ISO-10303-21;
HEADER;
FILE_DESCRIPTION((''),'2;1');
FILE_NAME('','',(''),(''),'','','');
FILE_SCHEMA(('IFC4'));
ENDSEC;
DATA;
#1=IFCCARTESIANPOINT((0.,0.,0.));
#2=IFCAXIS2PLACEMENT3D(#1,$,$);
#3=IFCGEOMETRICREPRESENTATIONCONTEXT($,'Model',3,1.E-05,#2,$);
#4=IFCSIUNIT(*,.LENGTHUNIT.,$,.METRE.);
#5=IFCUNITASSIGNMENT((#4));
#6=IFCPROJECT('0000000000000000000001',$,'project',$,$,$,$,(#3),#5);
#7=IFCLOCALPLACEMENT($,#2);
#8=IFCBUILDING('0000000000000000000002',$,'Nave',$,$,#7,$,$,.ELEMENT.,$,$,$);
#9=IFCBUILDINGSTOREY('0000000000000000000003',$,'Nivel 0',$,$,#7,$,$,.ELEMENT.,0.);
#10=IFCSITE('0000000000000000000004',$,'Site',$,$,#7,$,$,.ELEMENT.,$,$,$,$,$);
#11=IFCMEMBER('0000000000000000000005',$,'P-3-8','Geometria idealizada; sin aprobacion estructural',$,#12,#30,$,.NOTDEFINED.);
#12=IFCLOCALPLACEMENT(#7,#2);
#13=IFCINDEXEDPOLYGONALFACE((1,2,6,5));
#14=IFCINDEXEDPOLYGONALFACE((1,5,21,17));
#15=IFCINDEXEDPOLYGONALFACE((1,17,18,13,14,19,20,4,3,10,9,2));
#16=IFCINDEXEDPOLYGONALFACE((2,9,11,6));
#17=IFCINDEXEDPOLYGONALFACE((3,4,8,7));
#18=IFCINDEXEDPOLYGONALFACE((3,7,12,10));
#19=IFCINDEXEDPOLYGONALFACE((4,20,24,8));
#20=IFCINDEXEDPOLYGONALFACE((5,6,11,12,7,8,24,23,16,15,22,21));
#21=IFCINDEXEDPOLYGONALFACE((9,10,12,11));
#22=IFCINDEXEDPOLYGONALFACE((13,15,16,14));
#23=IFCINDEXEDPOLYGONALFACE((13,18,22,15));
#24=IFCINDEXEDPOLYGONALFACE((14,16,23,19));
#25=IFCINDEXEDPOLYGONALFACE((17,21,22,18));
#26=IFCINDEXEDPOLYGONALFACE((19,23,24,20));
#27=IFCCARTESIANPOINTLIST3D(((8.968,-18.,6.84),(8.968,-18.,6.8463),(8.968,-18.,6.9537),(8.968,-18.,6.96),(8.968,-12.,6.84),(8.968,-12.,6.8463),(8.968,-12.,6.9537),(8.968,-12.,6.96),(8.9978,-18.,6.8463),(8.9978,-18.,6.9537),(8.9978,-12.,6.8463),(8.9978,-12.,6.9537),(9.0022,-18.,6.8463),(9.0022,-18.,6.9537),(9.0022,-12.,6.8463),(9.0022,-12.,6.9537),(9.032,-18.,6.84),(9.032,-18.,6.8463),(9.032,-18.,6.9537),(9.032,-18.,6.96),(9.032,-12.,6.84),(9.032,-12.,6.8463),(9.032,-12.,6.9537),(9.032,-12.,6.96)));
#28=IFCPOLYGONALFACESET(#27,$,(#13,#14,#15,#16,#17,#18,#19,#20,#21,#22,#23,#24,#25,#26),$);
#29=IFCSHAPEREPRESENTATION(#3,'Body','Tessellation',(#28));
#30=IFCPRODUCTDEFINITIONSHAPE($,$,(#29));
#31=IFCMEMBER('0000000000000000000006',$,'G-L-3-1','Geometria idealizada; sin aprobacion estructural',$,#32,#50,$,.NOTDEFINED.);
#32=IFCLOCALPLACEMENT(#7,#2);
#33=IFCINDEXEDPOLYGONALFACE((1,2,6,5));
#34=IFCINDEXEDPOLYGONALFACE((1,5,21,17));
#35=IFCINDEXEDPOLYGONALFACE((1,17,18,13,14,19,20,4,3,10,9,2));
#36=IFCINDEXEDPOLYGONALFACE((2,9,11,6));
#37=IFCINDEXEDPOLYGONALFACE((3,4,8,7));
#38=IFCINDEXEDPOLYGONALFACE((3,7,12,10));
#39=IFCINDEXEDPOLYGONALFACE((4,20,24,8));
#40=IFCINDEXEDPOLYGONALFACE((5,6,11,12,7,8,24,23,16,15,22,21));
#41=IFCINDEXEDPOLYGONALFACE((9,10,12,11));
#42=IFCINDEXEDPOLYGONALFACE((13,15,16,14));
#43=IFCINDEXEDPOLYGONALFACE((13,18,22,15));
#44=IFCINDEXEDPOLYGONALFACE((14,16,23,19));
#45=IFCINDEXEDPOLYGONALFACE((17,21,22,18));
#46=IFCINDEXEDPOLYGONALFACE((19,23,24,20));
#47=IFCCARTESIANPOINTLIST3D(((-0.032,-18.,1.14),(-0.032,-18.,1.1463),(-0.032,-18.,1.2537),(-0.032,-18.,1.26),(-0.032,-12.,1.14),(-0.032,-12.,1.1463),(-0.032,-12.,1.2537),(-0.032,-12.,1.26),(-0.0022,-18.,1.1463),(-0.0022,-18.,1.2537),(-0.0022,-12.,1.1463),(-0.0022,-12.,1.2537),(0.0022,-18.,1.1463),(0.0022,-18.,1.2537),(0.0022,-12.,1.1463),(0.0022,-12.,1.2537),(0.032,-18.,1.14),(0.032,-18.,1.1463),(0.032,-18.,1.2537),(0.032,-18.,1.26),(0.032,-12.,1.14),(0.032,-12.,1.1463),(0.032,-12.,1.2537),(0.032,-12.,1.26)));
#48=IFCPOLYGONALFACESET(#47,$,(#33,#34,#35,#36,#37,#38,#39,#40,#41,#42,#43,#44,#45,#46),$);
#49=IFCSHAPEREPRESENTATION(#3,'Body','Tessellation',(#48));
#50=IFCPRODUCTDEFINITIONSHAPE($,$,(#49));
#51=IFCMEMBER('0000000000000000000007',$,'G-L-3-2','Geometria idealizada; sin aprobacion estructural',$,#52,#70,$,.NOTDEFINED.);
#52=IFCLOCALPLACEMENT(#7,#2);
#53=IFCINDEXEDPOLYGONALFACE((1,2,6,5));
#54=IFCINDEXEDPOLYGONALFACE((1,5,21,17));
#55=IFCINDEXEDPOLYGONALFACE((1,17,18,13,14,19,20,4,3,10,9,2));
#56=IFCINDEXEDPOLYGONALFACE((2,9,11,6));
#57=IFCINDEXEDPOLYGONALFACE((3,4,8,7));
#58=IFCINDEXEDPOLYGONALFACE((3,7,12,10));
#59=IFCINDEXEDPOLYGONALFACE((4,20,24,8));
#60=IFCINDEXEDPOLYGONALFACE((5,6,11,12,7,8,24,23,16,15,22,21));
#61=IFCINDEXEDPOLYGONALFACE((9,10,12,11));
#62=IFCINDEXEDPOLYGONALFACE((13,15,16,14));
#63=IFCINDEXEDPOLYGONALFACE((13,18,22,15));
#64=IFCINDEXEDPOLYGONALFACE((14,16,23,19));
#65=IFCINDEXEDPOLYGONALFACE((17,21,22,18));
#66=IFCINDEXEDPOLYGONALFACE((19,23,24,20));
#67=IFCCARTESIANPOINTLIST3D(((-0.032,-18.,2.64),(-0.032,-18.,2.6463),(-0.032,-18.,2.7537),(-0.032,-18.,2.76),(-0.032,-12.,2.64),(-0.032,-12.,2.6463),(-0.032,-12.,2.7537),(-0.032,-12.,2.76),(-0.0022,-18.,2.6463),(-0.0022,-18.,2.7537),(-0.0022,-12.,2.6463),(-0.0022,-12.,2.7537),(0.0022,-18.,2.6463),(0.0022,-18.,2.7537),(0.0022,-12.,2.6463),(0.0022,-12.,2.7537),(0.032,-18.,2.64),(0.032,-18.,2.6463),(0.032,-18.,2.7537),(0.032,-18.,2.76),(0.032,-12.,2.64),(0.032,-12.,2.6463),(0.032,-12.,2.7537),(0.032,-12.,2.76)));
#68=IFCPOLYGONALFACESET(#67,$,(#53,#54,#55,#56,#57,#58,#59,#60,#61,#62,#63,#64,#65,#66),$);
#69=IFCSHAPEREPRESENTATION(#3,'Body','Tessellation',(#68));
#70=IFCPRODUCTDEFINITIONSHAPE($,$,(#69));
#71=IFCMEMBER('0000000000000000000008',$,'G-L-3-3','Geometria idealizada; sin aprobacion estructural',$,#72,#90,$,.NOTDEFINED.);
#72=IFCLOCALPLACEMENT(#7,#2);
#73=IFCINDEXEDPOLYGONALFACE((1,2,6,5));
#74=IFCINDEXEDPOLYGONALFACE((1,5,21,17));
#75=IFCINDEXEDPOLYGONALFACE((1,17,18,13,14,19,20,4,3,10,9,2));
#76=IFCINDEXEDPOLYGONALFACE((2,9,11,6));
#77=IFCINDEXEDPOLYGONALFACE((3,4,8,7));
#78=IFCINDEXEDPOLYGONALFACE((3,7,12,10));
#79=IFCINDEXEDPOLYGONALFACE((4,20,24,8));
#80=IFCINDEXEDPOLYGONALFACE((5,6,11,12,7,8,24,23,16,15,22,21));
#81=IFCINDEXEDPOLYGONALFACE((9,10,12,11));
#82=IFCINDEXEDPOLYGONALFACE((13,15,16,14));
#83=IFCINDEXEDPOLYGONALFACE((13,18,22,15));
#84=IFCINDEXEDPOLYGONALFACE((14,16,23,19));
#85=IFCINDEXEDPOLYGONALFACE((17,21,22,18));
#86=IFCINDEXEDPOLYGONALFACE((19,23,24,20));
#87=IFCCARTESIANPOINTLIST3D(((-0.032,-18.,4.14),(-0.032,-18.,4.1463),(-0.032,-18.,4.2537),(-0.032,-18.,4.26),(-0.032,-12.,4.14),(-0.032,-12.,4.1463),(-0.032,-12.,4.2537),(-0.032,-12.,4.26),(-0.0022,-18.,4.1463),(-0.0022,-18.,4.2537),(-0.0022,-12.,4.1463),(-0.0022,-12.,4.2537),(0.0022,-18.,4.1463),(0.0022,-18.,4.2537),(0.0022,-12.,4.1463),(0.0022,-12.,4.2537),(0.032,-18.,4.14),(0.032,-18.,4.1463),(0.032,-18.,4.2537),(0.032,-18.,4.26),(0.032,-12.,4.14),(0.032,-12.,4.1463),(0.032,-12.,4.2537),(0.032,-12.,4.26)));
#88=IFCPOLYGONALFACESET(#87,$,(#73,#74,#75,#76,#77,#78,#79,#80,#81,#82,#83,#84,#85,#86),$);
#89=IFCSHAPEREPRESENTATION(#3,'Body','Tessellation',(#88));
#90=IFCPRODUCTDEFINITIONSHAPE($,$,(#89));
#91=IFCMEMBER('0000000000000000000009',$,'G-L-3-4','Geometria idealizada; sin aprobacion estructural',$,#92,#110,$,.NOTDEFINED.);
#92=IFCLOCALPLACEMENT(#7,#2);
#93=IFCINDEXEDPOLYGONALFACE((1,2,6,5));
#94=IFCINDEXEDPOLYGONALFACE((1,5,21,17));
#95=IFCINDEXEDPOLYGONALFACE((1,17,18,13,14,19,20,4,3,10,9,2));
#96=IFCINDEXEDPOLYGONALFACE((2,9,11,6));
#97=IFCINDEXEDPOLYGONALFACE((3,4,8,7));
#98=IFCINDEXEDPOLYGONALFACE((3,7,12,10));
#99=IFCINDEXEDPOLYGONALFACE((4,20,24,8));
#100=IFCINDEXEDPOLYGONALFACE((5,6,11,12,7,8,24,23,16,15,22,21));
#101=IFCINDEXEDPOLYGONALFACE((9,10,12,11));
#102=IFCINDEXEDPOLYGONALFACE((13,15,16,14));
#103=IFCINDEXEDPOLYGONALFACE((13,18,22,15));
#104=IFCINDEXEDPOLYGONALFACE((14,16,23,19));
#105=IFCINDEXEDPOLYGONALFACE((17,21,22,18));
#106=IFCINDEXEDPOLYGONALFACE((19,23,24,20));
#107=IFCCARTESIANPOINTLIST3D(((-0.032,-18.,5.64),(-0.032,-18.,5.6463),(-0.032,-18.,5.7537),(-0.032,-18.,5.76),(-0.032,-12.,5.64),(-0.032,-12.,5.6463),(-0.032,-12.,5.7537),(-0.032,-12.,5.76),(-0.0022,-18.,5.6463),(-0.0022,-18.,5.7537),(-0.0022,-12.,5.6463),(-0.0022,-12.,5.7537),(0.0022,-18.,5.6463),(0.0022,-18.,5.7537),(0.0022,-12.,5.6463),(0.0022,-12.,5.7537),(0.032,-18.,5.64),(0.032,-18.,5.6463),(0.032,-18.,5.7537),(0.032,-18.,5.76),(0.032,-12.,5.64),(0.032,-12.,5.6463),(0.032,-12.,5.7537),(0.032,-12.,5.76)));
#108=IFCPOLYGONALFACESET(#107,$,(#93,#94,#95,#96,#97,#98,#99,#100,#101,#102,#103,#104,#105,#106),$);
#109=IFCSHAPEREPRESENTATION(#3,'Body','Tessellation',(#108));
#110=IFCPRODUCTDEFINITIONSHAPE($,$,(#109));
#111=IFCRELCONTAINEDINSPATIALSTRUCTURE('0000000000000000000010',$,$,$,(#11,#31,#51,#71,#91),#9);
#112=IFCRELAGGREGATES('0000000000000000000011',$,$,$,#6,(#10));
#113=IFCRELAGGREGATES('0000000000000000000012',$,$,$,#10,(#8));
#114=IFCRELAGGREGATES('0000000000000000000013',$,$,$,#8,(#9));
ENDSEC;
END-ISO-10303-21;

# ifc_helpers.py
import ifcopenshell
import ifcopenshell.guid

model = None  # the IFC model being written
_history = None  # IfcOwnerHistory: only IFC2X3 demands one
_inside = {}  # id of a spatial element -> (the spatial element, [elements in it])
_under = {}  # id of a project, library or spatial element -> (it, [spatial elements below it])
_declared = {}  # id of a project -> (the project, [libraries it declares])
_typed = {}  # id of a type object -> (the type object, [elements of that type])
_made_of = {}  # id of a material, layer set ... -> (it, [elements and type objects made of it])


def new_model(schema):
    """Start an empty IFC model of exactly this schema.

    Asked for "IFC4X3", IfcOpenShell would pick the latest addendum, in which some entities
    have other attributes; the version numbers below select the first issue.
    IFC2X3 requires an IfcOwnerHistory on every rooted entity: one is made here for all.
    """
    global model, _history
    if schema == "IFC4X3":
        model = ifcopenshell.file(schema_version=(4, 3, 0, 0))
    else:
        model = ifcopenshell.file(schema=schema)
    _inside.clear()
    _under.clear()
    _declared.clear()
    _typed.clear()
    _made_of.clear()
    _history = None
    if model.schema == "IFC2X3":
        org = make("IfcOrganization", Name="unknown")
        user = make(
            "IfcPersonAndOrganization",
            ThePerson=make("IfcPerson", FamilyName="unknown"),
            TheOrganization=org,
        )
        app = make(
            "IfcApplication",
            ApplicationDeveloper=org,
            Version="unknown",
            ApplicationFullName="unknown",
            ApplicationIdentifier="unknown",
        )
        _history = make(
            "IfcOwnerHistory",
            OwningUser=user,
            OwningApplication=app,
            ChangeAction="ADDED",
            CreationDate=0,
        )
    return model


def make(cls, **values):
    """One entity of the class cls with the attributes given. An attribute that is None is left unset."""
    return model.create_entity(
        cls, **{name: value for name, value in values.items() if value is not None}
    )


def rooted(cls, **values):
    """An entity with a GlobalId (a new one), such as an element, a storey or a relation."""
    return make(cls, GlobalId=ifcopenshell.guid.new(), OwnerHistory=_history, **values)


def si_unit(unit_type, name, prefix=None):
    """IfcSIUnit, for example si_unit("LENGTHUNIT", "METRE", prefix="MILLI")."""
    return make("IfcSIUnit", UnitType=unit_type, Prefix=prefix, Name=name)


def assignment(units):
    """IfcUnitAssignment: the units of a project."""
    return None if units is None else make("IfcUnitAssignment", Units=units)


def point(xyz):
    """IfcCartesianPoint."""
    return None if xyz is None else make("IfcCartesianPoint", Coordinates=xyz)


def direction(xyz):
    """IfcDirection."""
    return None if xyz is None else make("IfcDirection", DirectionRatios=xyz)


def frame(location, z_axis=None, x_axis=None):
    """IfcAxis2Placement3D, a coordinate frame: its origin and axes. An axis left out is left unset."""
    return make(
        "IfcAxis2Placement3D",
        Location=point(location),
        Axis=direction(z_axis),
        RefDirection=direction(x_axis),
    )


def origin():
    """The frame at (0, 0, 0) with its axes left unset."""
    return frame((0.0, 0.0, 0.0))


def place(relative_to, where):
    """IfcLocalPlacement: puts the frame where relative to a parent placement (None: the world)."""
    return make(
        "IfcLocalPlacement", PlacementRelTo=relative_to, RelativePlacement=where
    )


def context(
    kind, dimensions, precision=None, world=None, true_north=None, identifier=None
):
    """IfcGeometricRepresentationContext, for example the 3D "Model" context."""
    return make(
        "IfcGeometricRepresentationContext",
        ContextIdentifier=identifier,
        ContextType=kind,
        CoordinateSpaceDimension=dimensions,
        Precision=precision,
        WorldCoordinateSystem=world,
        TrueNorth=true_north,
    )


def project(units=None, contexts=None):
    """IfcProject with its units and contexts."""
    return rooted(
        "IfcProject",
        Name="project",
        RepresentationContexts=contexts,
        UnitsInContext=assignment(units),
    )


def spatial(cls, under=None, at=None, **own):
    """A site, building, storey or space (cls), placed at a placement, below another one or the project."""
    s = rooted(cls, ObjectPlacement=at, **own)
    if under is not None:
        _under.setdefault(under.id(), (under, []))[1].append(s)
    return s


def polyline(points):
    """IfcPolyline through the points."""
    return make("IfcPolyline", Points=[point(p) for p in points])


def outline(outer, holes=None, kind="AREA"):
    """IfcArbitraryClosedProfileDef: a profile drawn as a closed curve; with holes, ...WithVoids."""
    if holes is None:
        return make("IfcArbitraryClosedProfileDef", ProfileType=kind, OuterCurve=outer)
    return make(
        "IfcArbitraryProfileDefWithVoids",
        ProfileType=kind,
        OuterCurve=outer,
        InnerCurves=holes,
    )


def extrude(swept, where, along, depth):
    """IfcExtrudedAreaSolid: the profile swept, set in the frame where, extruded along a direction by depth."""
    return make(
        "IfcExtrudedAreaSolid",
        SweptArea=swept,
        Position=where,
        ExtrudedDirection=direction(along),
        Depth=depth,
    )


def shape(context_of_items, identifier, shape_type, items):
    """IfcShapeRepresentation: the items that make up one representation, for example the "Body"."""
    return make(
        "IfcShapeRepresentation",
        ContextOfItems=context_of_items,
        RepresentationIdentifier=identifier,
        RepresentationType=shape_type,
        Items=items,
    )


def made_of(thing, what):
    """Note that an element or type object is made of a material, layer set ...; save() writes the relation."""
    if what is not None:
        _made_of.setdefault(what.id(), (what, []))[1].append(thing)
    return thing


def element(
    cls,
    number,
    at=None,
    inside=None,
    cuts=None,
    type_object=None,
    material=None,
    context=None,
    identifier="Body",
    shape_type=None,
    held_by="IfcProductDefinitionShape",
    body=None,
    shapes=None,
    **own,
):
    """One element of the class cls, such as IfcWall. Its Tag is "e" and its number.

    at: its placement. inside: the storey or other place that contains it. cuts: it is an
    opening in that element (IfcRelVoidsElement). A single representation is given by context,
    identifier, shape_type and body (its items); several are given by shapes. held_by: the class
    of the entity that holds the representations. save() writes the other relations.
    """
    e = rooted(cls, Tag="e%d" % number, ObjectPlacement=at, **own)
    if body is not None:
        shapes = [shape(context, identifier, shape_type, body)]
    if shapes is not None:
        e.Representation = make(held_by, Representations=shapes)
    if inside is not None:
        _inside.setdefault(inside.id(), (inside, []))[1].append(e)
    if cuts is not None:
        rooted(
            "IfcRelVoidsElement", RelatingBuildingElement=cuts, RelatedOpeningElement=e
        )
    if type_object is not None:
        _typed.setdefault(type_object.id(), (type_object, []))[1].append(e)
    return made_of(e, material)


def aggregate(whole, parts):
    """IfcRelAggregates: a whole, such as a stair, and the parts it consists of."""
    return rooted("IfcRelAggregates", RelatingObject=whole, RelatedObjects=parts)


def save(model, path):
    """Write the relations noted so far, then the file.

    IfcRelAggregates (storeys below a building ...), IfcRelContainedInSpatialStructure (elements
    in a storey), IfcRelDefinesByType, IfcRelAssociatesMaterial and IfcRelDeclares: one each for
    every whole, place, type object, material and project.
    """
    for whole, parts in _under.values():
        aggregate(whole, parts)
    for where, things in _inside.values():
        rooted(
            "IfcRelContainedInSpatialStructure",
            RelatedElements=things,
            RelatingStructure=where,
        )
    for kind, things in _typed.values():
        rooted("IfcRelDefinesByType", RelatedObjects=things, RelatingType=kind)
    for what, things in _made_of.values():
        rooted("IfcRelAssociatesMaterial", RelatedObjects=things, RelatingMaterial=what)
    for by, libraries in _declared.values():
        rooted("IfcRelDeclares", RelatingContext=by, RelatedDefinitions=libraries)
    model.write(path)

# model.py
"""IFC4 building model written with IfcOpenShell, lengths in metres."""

from ifc_helpers import new_model, si_unit, frame, origin, place, context, project, spatial, polyline, outline, extrude, element, save


model = new_model("IFC4")

# Units and contexts
model_context = context("Model", 3, precision=1e-05, world=origin())
ifc_project = project(units=[si_unit("LENGTHUNIT", "METRE")], contexts=[model_context])

# Site, building, storey
placement = place(None, origin())
site = spatial("IfcSite", under=ifc_project, at=placement, Name="Site", CompositionType="ELEMENT")
building = spatial("IfcBuilding", under=site, at=placement, Name="Nave", CompositionType="ELEMENT")
storey = spatial("IfcBuildingStorey", under=building, at=placement, Name="Nivel 0", CompositionType="ELEMENT", Elevation=0.0)

# Members
for number, where, z_axis, x_axis, name in (
    (1, (9.0, -12.0, 6.9), (0.0, -1.0, 0.0), (1.0, 0.0, 0.0), "P-3-8"),
    (2, (0.0, -12.0, 1.2), (0.0, -1.0, 0.0), (1.0, 0.0, 0.0), "G-L-3-1"),
    (3, (0.0, -12.0, 2.7), (0.0, -1.0, 0.0), (1.0, 0.0, 0.0), "G-L-3-2"),
    (4, (0.0, -12.0, 4.2), (0.0, -1.0, 0.0), (1.0, 0.0, 0.0), "G-L-3-3"),
    (5, (0.0, -12.0, 5.7), (0.0, -1.0, 0.0), (1.0, 0.0, 0.0), "G-L-3-4"),
):
    element("IfcMember", number, at=place(placement, frame(where, z_axis=z_axis, x_axis=x_axis)), inside=storey, Name=name, Description="Geometria idealizada; sin aprobacion estructural", PredefinedType="NOTDEFINED", context=model_context, shape_type="SweptSolid", body=[
        extrude(outline(polyline([(-0.032, -0.06), (0.032, -0.06), (0.032, -0.0537), (0.0022, -0.0537), (0.0022, 0.0537), (0.032, 0.0537), (0.032, 0.06), (-0.032, 0.06), (-0.032, 0.0537), (-0.0022, 0.0537), (-0.0022, -0.0537), (-0.032, -0.0537), (-0.032, -0.06)])), origin(), (0.0, 0.0, 1.0), 6.0),
    ])

save(model, "model.ifc")
